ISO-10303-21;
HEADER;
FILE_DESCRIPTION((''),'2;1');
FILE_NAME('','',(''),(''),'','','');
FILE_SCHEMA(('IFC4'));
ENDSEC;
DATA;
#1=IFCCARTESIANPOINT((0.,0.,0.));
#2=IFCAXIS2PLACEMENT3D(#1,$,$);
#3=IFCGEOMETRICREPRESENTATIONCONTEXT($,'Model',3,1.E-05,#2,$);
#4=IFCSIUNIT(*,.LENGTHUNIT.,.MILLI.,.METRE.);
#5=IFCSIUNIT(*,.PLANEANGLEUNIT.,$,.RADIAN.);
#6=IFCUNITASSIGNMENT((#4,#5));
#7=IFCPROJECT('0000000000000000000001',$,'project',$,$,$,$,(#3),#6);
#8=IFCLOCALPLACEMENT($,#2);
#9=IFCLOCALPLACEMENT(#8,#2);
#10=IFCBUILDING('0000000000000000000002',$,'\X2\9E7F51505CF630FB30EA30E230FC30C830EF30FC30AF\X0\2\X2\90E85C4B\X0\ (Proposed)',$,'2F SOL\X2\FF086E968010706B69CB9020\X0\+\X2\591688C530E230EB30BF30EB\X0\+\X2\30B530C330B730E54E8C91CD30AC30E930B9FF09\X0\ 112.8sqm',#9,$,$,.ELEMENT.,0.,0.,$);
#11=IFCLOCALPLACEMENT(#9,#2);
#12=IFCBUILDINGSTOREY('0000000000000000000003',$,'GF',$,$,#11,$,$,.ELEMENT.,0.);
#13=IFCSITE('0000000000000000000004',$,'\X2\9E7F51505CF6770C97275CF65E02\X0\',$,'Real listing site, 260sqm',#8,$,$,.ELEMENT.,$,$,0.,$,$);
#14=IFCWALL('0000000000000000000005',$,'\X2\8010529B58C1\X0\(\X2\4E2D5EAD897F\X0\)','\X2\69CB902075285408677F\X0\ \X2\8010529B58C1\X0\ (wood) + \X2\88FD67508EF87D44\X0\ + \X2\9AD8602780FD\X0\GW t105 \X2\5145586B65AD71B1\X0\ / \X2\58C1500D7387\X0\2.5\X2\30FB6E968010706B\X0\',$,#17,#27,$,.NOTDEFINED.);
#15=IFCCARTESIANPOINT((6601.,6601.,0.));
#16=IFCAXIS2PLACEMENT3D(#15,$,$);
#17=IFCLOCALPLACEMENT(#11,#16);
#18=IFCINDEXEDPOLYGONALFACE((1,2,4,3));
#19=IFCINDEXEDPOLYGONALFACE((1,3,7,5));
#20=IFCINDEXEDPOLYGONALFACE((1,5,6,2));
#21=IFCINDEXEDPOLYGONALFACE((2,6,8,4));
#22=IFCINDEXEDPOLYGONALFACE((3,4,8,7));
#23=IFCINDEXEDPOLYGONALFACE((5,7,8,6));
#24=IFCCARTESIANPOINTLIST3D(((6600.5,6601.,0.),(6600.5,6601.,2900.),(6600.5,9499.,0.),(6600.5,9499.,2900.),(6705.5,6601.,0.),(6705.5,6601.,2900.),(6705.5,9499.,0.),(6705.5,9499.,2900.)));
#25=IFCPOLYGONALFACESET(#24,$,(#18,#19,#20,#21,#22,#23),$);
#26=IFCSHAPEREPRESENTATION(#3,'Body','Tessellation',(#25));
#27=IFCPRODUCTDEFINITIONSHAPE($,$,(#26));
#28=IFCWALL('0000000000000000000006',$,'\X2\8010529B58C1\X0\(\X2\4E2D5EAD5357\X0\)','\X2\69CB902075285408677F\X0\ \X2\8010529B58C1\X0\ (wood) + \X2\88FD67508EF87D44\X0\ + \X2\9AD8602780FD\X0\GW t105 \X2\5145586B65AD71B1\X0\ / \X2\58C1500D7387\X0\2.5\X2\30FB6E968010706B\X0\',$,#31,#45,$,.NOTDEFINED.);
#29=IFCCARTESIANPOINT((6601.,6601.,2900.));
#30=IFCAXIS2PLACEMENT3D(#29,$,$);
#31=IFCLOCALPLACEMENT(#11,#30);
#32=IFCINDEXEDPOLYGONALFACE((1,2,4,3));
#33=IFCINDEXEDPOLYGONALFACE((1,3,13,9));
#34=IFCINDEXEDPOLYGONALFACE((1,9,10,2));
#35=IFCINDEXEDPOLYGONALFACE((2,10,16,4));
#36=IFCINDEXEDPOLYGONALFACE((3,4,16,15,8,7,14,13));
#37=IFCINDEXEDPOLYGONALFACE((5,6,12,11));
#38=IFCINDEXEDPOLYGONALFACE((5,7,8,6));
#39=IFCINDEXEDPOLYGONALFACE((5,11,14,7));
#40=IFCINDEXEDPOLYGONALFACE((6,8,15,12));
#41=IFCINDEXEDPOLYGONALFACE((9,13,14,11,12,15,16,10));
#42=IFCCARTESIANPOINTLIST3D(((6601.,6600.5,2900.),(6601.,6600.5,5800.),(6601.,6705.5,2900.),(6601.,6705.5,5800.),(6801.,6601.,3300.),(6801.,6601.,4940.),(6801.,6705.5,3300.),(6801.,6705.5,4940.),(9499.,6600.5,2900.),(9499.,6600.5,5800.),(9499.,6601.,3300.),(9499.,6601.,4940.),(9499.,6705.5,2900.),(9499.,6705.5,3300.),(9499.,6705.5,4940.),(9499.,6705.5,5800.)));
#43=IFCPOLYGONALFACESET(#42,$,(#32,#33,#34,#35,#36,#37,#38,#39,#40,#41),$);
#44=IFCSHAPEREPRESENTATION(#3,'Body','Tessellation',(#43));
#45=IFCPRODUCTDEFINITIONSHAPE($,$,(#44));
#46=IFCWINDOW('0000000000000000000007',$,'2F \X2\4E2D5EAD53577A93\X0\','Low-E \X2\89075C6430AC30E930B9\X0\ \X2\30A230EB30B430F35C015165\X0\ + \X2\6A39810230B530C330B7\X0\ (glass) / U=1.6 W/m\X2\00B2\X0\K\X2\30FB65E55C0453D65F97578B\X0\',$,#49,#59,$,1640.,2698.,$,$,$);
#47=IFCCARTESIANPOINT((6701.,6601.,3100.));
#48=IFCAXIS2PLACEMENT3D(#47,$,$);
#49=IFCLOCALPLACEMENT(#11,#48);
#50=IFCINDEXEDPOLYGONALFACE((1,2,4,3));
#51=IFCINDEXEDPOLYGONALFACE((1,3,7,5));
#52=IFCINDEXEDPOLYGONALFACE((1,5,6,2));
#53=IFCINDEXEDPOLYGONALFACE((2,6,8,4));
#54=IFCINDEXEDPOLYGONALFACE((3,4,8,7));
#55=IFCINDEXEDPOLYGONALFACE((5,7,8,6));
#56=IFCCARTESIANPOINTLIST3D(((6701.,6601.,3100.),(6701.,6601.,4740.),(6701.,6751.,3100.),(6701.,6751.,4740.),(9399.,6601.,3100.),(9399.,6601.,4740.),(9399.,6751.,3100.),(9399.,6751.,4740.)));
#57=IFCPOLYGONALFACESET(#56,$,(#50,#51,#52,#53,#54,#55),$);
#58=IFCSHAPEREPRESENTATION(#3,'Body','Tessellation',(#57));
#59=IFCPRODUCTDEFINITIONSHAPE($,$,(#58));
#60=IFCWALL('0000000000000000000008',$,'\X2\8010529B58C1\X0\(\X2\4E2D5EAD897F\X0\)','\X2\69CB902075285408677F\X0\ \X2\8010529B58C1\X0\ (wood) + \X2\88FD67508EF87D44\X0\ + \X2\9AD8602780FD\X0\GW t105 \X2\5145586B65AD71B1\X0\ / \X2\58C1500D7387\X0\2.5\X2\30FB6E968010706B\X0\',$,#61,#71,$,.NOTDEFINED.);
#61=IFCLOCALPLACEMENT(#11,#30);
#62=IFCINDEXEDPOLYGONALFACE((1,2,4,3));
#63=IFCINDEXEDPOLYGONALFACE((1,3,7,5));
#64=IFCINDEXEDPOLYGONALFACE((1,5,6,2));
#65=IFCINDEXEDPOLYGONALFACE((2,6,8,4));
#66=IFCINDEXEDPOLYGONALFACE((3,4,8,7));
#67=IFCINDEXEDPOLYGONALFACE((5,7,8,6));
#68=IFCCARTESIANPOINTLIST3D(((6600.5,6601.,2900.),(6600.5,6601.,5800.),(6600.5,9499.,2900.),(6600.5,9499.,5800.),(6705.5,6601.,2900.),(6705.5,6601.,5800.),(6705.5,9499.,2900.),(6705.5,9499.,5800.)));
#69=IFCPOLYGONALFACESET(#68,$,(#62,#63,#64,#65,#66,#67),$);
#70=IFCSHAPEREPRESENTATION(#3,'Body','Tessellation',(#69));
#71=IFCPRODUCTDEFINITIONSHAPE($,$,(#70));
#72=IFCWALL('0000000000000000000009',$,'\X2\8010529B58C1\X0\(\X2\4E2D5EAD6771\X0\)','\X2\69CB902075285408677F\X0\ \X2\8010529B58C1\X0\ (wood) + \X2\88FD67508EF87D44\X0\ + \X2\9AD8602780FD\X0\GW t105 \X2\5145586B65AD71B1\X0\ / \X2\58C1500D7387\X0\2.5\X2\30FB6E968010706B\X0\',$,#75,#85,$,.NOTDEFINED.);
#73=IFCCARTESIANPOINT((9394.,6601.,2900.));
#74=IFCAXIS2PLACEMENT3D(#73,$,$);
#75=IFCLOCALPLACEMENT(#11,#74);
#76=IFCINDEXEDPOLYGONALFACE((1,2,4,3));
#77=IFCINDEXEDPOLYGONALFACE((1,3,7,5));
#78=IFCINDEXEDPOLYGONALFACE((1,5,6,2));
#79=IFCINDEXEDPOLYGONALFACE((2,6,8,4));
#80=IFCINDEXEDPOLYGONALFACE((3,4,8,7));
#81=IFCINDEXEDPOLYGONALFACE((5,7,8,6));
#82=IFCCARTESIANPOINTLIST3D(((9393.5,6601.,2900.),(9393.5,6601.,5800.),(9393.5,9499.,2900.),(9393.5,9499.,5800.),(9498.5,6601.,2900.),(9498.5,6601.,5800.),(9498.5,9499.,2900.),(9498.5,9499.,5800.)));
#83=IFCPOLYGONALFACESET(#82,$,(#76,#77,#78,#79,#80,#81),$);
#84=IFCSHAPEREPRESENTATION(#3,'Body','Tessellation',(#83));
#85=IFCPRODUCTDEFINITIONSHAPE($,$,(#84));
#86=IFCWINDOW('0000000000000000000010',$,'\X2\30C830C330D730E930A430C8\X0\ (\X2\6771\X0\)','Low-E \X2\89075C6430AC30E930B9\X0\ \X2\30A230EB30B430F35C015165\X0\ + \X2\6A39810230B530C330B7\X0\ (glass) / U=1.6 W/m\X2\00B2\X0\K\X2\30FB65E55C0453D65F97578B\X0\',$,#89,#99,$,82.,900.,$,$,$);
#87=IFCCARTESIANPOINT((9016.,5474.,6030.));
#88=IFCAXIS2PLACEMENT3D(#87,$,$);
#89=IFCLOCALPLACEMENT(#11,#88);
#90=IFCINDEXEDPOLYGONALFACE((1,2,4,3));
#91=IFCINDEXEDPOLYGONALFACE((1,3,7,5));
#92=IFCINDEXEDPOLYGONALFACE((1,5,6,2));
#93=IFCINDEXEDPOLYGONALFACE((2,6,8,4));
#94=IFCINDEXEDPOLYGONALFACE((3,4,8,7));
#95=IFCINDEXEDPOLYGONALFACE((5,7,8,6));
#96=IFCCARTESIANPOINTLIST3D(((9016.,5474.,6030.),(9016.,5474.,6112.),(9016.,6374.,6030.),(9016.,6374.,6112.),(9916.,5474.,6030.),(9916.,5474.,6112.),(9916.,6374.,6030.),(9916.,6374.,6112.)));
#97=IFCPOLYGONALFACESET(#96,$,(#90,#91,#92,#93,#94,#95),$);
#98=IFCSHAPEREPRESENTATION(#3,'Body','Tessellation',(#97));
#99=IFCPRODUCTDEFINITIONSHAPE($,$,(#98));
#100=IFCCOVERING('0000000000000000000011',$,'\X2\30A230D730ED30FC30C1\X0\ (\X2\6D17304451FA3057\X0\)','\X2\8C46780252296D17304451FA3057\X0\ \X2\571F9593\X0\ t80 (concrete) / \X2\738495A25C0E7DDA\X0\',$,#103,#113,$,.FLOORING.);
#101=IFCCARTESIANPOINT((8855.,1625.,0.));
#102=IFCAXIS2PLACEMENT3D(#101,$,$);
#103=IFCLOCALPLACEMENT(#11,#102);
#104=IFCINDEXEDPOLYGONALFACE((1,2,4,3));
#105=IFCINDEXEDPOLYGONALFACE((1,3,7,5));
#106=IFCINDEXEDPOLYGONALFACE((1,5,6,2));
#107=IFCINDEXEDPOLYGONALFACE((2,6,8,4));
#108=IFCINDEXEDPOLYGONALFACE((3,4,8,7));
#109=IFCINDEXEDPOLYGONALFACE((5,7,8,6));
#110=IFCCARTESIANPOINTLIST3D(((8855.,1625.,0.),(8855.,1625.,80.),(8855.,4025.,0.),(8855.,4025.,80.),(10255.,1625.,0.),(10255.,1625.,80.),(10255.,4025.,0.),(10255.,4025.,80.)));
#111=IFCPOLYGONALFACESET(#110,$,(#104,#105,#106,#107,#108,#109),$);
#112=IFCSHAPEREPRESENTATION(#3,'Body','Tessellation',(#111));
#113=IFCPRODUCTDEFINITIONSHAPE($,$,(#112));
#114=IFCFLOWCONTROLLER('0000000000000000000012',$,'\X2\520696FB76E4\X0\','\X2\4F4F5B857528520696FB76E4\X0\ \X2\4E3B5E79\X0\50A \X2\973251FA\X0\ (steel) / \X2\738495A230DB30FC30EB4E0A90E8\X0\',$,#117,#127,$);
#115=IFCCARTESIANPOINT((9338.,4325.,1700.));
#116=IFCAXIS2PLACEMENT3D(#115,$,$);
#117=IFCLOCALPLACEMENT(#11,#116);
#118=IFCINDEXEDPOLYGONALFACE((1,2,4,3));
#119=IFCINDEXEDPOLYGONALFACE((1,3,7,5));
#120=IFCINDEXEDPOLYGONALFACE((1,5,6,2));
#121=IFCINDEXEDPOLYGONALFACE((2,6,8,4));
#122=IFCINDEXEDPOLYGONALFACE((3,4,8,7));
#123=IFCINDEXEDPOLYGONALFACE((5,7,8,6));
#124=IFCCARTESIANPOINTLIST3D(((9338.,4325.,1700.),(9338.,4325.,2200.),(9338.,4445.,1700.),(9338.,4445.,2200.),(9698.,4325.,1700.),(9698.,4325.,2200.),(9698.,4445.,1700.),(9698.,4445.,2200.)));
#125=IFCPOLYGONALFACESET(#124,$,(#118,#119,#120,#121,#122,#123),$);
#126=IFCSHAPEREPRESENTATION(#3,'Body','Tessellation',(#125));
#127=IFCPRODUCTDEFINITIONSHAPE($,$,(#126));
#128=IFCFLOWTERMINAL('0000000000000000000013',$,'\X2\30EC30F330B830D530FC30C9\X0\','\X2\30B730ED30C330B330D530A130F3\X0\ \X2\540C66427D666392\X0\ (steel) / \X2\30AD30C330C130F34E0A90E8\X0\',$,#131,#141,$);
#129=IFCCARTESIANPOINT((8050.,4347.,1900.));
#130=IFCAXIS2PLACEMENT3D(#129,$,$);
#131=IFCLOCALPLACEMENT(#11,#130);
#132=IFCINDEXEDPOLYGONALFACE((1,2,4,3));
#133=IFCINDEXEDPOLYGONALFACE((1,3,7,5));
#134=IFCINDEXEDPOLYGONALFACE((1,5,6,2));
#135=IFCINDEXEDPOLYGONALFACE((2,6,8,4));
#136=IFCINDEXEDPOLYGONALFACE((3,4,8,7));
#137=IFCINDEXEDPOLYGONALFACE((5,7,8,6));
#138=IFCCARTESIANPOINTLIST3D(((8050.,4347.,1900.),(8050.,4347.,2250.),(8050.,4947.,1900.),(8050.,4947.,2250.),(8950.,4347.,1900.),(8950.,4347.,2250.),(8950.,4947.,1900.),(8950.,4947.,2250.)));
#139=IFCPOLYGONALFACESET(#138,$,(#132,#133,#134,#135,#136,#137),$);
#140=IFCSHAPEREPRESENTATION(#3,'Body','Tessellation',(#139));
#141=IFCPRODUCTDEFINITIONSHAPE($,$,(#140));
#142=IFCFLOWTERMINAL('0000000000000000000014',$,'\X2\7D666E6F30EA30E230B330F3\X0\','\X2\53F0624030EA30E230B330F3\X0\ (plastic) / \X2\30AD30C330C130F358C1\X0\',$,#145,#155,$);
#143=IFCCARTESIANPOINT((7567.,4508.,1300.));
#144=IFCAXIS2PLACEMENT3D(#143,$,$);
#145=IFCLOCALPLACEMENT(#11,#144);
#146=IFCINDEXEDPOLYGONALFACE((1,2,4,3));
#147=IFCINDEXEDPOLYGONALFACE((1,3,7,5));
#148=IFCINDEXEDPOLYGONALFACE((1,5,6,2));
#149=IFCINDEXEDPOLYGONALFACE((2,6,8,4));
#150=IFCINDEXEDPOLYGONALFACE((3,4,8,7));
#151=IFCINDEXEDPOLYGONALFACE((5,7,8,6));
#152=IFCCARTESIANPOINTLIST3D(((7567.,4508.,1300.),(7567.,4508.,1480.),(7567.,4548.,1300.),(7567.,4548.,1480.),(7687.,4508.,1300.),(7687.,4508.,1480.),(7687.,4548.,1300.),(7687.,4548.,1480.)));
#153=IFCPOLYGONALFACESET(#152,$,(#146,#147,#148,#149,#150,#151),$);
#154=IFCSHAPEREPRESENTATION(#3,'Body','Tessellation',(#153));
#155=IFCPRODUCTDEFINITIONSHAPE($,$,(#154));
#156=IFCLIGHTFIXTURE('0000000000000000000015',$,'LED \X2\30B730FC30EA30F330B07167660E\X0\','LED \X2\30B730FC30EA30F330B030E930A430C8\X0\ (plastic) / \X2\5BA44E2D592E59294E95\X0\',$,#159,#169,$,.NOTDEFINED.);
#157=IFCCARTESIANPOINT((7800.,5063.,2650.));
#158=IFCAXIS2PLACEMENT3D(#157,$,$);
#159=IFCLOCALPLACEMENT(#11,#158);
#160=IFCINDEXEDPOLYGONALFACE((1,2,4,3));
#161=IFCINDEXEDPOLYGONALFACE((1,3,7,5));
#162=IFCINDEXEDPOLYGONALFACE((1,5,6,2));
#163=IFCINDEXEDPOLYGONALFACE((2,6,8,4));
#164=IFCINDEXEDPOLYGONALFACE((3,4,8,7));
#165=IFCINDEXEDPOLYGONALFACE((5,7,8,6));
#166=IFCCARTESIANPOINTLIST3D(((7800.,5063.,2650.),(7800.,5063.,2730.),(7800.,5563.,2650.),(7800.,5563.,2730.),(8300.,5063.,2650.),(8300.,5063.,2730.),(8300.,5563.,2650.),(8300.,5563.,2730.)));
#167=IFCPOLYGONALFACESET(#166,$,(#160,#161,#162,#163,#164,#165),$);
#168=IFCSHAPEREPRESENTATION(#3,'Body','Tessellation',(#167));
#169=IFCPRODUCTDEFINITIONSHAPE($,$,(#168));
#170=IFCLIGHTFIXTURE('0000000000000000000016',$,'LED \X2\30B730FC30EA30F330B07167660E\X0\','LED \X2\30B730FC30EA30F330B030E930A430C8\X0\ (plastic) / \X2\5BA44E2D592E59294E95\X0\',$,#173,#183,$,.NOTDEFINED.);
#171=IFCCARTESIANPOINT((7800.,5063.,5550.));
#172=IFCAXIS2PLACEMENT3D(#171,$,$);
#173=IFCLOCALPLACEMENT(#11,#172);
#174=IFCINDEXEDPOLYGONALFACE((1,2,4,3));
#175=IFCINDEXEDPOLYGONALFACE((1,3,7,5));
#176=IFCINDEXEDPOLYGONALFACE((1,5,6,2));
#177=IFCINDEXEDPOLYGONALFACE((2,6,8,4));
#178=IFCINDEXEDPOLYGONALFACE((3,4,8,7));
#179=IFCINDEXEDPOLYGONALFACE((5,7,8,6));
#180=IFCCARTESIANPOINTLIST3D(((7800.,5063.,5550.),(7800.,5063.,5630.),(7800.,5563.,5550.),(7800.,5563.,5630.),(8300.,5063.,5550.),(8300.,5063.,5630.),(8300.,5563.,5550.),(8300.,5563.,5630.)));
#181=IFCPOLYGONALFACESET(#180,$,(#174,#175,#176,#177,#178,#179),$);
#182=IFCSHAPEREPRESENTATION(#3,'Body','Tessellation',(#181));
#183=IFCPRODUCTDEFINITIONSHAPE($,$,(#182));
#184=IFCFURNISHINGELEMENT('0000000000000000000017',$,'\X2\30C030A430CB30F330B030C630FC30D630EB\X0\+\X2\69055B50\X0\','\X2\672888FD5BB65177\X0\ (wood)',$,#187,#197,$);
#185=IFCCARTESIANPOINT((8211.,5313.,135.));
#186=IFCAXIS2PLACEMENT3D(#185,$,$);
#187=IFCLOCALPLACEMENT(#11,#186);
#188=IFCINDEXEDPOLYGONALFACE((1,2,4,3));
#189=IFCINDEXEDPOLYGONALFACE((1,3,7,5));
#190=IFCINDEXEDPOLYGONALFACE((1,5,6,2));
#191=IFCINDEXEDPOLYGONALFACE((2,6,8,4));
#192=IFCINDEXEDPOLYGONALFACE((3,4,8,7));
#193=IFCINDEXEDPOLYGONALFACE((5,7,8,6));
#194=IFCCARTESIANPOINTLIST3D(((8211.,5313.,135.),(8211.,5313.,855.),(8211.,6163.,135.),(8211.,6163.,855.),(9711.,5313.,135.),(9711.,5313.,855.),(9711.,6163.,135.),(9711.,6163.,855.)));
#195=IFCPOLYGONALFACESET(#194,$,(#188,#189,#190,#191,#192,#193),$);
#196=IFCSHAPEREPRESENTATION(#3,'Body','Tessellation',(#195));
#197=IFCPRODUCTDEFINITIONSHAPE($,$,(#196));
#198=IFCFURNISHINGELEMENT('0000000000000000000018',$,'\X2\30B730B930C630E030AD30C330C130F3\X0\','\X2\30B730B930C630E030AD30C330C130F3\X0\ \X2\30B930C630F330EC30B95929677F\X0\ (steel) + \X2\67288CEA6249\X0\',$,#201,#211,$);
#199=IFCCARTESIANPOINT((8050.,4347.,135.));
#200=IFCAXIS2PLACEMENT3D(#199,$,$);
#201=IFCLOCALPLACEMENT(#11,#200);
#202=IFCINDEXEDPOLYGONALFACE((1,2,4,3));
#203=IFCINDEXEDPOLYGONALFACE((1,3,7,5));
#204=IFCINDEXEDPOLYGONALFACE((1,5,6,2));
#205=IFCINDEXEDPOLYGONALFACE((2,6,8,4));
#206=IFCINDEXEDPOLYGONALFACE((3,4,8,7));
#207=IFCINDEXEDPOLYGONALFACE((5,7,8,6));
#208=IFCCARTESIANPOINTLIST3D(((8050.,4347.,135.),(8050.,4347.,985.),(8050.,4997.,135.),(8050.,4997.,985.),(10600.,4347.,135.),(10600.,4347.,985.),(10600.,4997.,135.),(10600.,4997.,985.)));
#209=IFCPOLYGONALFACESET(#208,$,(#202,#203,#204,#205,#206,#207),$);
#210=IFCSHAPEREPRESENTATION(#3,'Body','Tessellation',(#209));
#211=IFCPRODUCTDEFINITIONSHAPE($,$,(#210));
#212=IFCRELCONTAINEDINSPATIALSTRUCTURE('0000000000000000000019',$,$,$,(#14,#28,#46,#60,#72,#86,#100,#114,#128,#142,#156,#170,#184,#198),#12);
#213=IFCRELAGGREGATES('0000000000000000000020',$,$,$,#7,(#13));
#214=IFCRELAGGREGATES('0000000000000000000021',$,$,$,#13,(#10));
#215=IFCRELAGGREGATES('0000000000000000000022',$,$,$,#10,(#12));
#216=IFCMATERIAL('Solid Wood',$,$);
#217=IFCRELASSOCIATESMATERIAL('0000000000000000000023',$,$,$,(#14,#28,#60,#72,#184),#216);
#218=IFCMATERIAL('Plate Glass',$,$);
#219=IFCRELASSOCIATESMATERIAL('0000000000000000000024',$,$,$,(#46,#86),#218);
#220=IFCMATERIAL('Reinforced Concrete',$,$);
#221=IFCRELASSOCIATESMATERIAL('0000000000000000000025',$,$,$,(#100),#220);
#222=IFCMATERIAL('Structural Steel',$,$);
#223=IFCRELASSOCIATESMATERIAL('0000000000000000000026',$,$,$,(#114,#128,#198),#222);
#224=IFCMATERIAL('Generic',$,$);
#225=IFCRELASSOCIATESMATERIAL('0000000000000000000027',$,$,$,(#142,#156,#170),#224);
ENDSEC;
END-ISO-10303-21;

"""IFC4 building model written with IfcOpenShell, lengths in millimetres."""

from ifc_helpers import new_model, si_unit, frame, frame_2d, origin, place, context, project, spatial, rectangle, extrude, material, element, fill, save


model = new_model("IFC4")

# Units and contexts
model_context = context("Model", 3, precision=1e-05, world=origin())
ifc_project = project(units=[si_unit("LENGTHUNIT", "METRE", prefix="MILLI"), si_unit("PLANEANGLEUNIT", "RADIAN")], contexts=[model_context])

# Site, building, storey
site_placement = place(None, origin())
site = spatial("IfcSite", under=ifc_project, at=site_placement, Name="鹿児島県霧島市", ObjectType="Real listing site, 260sqm", CompositionType="ELEMENT", RefElevation=0.0)
building_placement = place(site_placement, origin())
building = spatial("IfcBuilding", under=site, at=building_placement, Name="鹿児島・リモートワーク2部屋 (Proposed)", ObjectType="2F SOL（準耐火構造+外装モルタル+サッシュ二重ガラス） 112.8sqm", CompositionType="ELEMENT", ElevationOfRefHeight=0.0, ElevationOfTerrain=0.0)
storey_placement = place(building_placement, origin())
storey = spatial("IfcBuildingStorey", under=building, at=storey_placement, Name="GF", CompositionType="ELEMENT", Elevation=0.0)

# Shared definitions
ifc_material_1 = material(Name="Solid Wood")

# Wall
wall_1_placement = place(storey_placement, frame((6601.0, 6601.0, 0.0)))
element("IfcWall", 1, at=wall_1_placement, inside=storey, material=ifc_material_1, Name="耐力壁(中庭西)", Description="構造用合板 耐力壁 (wood) + 製材軸組 + 高性能GW t105 充填断熱 / 壁倍率2.5・準耐火", PredefinedType="NOTDEFINED", context=model_context, shape_type="SweptSolid", body=[
    extrude(rectangle(XDim=105.0, YDim=2898.0, at=frame_2d((52.0, 1449.0))), frame((6601.0, 6601.0, 0.0)), (0.0, 0.0, 1.0), 2900.0),
])

# Wall, opening, window
wall_2_placement = place(storey_placement, frame((6601.0, 6601.0, 2900.0)))
wall_2 = element("IfcWall", 2, at=wall_2_placement, inside=storey, material=ifc_material_1, Name="耐力壁(中庭南)", Description="構造用合板 耐力壁 (wood) + 製材軸組 + 高性能GW t105 充填断熱 / 壁倍率2.5・準耐火", PredefinedType="NOTDEFINED", context=model_context, shape_type="SweptSolid", body=[
    extrude(rectangle(XDim=2898.0, YDim=105.0, at=frame_2d((1449.0, 52.0))), frame((6601.0, 6601.0, 2900.0)), (0.0, 0.0, 1.0), 2900.0),
])
opening_placement = place(storey_placement, frame((6701.0, 6601.0, 3100.0)))
opening = element("IfcOpeningElement", 3, at=opening_placement, cuts=wall_2, PredefinedType="NOTDEFINED", context=model_context, shape_type="SweptSolid", body=[
    extrude(rectangle(XDim=2698.0, YDim=150.0, at=frame_2d((1349.0, 75.0))), frame((6701.0, 6601.0, 3100.0)), (0.0, 0.0, 1.0), 1640.0),
])
ifc_material_2 = material(Name="Plate Glass")
window_1_placement = place(storey_placement, frame((6701.0, 6601.0, 3100.0)))
window_1 = element("IfcWindow", 4, at=window_1_placement, inside=storey, material=ifc_material_2, Name="2F 中庭南窓", Description="Low-E 複層ガラス アルゴン封入 + 樹脂サッシ (glass) / U=1.6 W/m²K・日射取得型", OverallHeight=1640.0, OverallWidth=2698.0, context=model_context, shape_type="SweptSolid", body=[
    extrude(rectangle(XDim=2698.0, YDim=150.0, at=frame_2d((1349.0, 75.0))), frame((6701.0, 6601.0, 3100.0)), (0.0, 0.0, 1.0), 1640.0),
])
fill(opening, window_1)

# Walls
wall_3_placement = place(storey_placement, frame((6601.0, 6601.0, 2900.0)))
element("IfcWall", 5, at=wall_3_placement, inside=storey, material=ifc_material_1, Name="耐力壁(中庭西)", Description="構造用合板 耐力壁 (wood) + 製材軸組 + 高性能GW t105 充填断熱 / 壁倍率2.5・準耐火", PredefinedType="NOTDEFINED", context=model_context, shape_type="SweptSolid", body=[
    extrude(rectangle(XDim=105.0, YDim=2898.0, at=frame_2d((52.0, 1449.0))), frame((6601.0, 6601.0, 2900.0)), (0.0, 0.0, 1.0), 2900.0),
])
wall_4_placement = place(storey_placement, frame((9394.0, 6601.0, 2900.0)))
element("IfcWall", 6, at=wall_4_placement, inside=storey, material=ifc_material_1, Name="耐力壁(中庭東)", Description="構造用合板 耐力壁 (wood) + 製材軸組 + 高性能GW t105 充填断熱 / 壁倍率2.5・準耐火", PredefinedType="NOTDEFINED", context=model_context, shape_type="SweptSolid", body=[
    extrude(rectangle(XDim=105.0, YDim=2898.0, at=frame_2d((52.0, 1449.0))), frame((9394.0, 6601.0, 2900.0)), (0.0, 0.0, 1.0), 2900.0),
])

# Window
window_2_placement = place(storey_placement, frame((9016.0, 5474.0, 6030.0)))
element("IfcWindow", 7, at=window_2_placement, inside=storey, material=ifc_material_2, Name="トップライト (東)", Description="Low-E 複層ガラス アルゴン封入 + 樹脂サッシ (glass) / U=1.6 W/m²K・日射取得型", OverallHeight=82.0, OverallWidth=900.0, context=model_context, shape_type="SweptSolid", body=[
    extrude(rectangle(XDim=900.0, YDim=900.0, at=frame_2d((450.0, 450.0))), frame((9016.0, 5474.0, 6030.0)), (0.0, 0.0, 1.0), 82.0),
])

# Covering
ifc_material_3 = material(Name="Reinforced Concrete")
covering_placement = place(storey_placement, frame((8855.0, 1625.0, 0.0)))
element("IfcCovering", 8, at=covering_placement, inside=storey, material=ifc_material_3, Name="アプローチ (洗い出し)", Description="豆砂利洗い出し 土間 t80 (concrete) / 玄関導線", PredefinedType="FLOORING", context=model_context, shape_type="SweptSolid", body=[
    extrude(rectangle(XDim=1400.0, YDim=2400.0, at=frame_2d((700.0, 1200.0))), frame((8855.0, 1625.0, 0.0)), (0.0, 0.0, 1.0), 80.0),
])

# Flow controller
ifc_material_4 = material(Name="Structural Steel")
flow_controller_placement = place(storey_placement, frame((9338.0, 4325.0, 1700.0)))
element("IfcFlowController", 9, at=flow_controller_placement, inside=storey, material=ifc_material_4, Name="分電盤", Description="住宅用分電盤 主幹50A 露出 (steel) / 玄関ホール上部", context=model_context, shape_type="SweptSolid", body=[
    extrude(rectangle(XDim=360.0, YDim=120.0, at=frame_2d((180.0, 60.0))), frame((9338.0, 4325.0, 1700.0)), (0.0, 0.0, 1.0), 500.0),
])

# Flow terminals
flow_terminal_1_placement = place(storey_placement, frame((8050.0, 4347.0, 1900.0)))
element("IfcFlowTerminal", 10, at=flow_terminal_1_placement, inside=storey, material=ifc_material_4, Name="レンジフード", Description="シロッコファン 同時給排 (steel) / キッチン上部", context=model_context, shape_type="SweptSolid", body=[
    extrude(rectangle(XDim=900.0, YDim=600.0, at=frame_2d((450.0, 300.0))), frame((8050.0, 4347.0, 1900.0)), (0.0, 0.0, 1.0), 350.0),
])
ifc_material_5 = material(Name="Generic")
flow_terminal_2_placement = place(storey_placement, frame((7567.0, 4508.0, 1300.0)))
element("IfcFlowTerminal", 11, at=flow_terminal_2_placement, inside=storey, material=ifc_material_5, Name="給湯リモコン", Description="台所リモコン (plastic) / キッチン壁", context=model_context, shape_type="SweptSolid", body=[
    extrude(rectangle(XDim=120.0, YDim=40.0, at=frame_2d((60.0, 20.0))), frame((7567.0, 4508.0, 1300.0)), (0.0, 0.0, 1.0), 180.0),
])

# Light fixtures
light_fixture_1_placement = place(storey_placement, frame((7800.0, 5063.0, 2650.0)))
element("IfcLightFixture", 12, at=light_fixture_1_placement, inside=storey, material=ifc_material_5, Name="LED シーリング照明", Description="LED シーリングライト (plastic) / 室中央天井", PredefinedType="NOTDEFINED", context=model_context, shape_type="SweptSolid", body=[
    extrude(rectangle(XDim=500.0, YDim=500.0, at=frame_2d((250.0, 250.0))), frame((7800.0, 5063.0, 2650.0)), (0.0, 0.0, 1.0), 80.0),
])
light_fixture_2_placement = place(storey_placement, frame((7800.0, 5063.0, 5550.0)))
element("IfcLightFixture", 13, at=light_fixture_2_placement, inside=storey, material=ifc_material_5, Name="LED シーリング照明", Description="LED シーリングライト (plastic) / 室中央天井", PredefinedType="NOTDEFINED", context=model_context, shape_type="SweptSolid", body=[
    extrude(rectangle(XDim=500.0, YDim=500.0, at=frame_2d((250.0, 250.0))), frame((7800.0, 5063.0, 5550.0)), (0.0, 0.0, 1.0), 80.0),
])

# Furnishing elements
furnishing_1_placement = place(storey_placement, frame((8211.0, 5313.0, 135.0)))
element("IfcFurnishingElement", 14, at=furnishing_1_placement, inside=storey, material=ifc_material_1, Name="ダイニングテーブル+椅子", Description="木製家具 (wood)", context=model_context, shape_type="SweptSolid", body=[
    extrude(rectangle(XDim=1500.0, YDim=850.0, at=frame_2d((750.0, 425.0))), frame((8211.0, 5313.0, 135.0)), (0.0, 0.0, 1.0), 720.0),
])
furnishing_2_placement = place(storey_placement, frame((8050.0, 4347.0, 135.0)))
element("IfcFurnishingElement", 15, at=furnishing_2_placement, inside=storey, material=ifc_material_4, Name="システムキッチン", Description="システムキッチン ステンレス天板 (steel) + 木質扉", context=model_context, shape_type="SweptSolid", body=[
    extrude(rectangle(XDim=2550.0, YDim=650.0, at=frame_2d((1275.0, 325.0))), frame((8050.0, 4347.0, 135.0)), (0.0, 0.0, 1.0), 850.0),
])

save(model, "model.ifc")
